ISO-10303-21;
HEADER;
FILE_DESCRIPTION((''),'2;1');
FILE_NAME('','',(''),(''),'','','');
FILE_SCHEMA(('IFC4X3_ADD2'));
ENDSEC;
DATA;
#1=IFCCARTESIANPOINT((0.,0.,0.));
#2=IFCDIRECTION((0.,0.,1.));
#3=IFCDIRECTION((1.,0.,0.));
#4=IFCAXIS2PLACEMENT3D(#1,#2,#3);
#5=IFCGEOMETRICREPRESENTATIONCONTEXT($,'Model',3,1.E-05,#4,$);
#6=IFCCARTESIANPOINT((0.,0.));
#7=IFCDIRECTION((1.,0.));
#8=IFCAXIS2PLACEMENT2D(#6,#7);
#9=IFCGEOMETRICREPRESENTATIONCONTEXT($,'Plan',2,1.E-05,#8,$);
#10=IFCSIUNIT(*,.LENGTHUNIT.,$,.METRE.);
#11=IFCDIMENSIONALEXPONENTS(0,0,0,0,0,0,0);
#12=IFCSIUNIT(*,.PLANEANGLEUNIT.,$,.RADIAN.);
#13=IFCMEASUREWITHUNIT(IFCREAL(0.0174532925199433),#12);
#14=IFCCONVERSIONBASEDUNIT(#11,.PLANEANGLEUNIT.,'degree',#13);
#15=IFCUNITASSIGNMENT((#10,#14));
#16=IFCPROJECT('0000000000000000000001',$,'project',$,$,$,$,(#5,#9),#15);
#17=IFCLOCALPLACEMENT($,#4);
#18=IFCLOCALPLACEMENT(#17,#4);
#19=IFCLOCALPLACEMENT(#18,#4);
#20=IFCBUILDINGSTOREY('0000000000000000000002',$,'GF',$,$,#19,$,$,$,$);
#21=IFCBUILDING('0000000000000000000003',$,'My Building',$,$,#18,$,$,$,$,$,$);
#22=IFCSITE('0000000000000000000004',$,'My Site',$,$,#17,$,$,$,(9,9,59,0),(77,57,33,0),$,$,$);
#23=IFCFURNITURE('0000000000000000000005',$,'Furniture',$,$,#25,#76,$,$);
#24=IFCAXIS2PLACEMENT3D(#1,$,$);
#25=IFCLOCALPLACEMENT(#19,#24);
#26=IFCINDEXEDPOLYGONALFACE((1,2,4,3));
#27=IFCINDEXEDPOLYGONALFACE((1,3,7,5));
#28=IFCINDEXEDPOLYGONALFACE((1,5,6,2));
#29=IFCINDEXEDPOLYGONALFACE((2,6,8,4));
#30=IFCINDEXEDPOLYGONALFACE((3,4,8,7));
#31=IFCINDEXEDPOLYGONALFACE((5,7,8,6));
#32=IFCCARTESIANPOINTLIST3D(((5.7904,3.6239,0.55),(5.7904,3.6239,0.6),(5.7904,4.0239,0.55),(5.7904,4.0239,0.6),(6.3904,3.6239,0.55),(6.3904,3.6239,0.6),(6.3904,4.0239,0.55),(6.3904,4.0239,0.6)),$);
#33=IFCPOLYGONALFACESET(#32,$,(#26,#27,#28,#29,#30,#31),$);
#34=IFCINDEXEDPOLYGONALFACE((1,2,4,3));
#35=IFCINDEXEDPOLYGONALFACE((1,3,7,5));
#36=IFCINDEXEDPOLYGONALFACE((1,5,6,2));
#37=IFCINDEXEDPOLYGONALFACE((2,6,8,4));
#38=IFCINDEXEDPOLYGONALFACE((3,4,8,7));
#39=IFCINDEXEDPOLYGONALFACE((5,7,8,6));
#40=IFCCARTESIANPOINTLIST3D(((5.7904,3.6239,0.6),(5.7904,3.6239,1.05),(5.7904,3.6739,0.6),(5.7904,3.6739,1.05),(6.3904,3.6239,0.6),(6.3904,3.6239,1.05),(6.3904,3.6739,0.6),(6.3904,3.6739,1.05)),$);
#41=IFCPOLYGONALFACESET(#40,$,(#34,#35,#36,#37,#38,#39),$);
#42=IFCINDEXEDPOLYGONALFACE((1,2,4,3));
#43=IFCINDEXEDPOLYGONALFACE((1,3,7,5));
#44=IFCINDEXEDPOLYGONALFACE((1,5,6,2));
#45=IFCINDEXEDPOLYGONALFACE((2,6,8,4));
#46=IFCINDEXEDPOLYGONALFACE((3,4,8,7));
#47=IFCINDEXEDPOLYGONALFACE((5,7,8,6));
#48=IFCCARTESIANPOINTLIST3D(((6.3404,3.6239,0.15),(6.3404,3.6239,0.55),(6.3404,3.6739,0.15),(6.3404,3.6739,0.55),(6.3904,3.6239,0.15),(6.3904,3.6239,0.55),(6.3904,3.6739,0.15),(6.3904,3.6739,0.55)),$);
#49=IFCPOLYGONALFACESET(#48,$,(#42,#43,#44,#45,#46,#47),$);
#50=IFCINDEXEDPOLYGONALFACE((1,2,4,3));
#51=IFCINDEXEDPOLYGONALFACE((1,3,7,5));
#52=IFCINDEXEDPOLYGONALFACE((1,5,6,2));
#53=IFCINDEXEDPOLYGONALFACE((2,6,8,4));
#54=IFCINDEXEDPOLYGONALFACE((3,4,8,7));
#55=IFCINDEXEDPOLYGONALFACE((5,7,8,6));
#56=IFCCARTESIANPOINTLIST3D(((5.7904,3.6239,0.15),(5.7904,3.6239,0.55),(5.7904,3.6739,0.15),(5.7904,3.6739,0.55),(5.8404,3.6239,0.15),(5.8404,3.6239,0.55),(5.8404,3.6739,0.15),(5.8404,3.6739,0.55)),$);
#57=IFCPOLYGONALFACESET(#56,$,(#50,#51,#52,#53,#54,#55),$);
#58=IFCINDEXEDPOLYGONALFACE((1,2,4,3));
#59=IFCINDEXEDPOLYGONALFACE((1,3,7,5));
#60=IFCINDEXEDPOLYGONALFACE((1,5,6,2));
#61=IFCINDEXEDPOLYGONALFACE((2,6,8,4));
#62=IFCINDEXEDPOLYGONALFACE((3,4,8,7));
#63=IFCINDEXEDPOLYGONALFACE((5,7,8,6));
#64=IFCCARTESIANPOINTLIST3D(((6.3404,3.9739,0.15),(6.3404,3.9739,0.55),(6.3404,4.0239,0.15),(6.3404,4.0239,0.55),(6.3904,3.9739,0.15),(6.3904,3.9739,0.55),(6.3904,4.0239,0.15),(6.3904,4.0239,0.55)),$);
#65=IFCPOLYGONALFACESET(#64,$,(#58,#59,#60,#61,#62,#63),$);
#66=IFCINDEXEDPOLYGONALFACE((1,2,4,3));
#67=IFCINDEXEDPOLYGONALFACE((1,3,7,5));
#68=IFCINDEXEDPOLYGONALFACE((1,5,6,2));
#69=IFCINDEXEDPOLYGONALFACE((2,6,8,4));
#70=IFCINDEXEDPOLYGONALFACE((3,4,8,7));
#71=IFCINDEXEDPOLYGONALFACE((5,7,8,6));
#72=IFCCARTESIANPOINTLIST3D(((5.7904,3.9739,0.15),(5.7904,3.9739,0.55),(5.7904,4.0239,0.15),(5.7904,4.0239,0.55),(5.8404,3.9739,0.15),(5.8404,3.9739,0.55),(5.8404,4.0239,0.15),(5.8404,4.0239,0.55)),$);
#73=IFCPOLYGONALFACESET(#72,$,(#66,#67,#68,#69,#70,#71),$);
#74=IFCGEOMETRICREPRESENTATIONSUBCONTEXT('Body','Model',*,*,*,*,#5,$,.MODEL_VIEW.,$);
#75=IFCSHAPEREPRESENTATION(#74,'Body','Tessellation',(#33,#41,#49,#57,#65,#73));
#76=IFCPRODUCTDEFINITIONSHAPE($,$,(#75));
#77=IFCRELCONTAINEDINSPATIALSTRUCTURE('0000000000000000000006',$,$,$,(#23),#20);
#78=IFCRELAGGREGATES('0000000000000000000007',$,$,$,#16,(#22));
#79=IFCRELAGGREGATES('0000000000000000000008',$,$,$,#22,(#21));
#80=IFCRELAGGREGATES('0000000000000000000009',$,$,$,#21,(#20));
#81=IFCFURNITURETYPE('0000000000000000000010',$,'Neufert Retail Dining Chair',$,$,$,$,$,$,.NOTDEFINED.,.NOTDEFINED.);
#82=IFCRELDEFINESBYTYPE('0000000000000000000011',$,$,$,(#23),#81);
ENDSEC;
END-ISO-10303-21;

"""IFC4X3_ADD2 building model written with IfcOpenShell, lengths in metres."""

from ifc_helpers import new_model, entity, si_unit, converted_unit, frame, origin_with_axes, origin_2d_with_axis, place, context, subcontext, project, spatial, line, indexed_curve, outline, extrude, shape, source, transform, mapped, type_object, type_shapes, element, save


model = new_model("IFC4X3_ADD2")

# Units and contexts
model_context = context("Model", 3, precision=1e-05, world=origin_with_axes())
plan_context = context("Plan", 2, precision=1e-05, world=origin_2d_with_axis())
body_context_1 = subcontext(model_context, "Body", "Model", "MODEL_VIEW")
body_context_2 = subcontext(plan_context, "Body", "Plan", "PLAN_VIEW")
ifc_project = project(units=[si_unit("LENGTHUNIT", "METRE"), converted_unit("PLANEANGLEUNIT", "degree", entity("IfcReal", 0.0174532925199433), si_unit("PLANEANGLEUNIT", "RADIAN"), dimensions=[0, 0, 0, 0, 0, 0, 0])], contexts=[model_context, plan_context])

# Site, building, storey
site_placement = place(None, origin_with_axes())
site = spatial("IfcSite", under=ifc_project, at=site_placement, Name="My Site", RefLatitude=(9, 9, 59, 0), RefLongitude=(77, 57, 33, 0))
building_placement = place(site_placement, origin_with_axes())
building = spatial("IfcBuilding", under=site, at=building_placement, Name="My Building")
storey_placement = place(building_placement, origin_with_axes())
storey = spatial("IfcBuildingStorey", under=building, at=storey_placement, Name="GF")

# Furniture
furniture_type = type_object("IfcFurnitureType", Name="Neufert Retail Dining Chair", AssemblyPlace="NOTDEFINED", PredefinedType="NOTDEFINED")
shared_shape_1 = source(origin_with_axes(), body_context_1, "Body", "SweptSolid", [
    extrude(outline(indexed_curve([(-0.3, 0.0), (0.3, 0.0), (0.3, -0.4), (-0.3, -0.4)], segments=[line(1, 2, 3, 4, 1)])), frame((0.0, 0.0, 0.45), z_axis=(0.0, 0.0, 1.0), x_axis=(1.0, 0.0, 0.0)), (0.0, 0.0, -1.0), 0.05),
    extrude(outline(indexed_curve([(-0.3, 0.0), (0.3, 0.0), (0.3, -0.05), (-0.3, -0.05)], segments=[line(1, 2, 3, 4, 1)])), frame((0.0, 0.0, 0.9), z_axis=(0.0, 0.0, 1.0), x_axis=(1.0, 0.0, 0.0)), (0.0, 0.0, -1.0), 0.45),
    extrude(outline(indexed_curve([(-0.3, 0.0), (-0.25, 0.0), (-0.25, -0.05), (-0.3, -0.05)], segments=[line(1, 2, 3, 4, 1)])), origin_with_axes(), (0.0, 0.0, 1.0), 0.4),
    extrude(outline(indexed_curve([(0.3, 0.0), (0.25, 0.0), (0.25, -0.05), (0.3, -0.05)], segments=[line(1, 2, 3, 4, 1)])), origin_with_axes(), (0.0, 0.0, 1.0), 0.4),
    extrude(outline(indexed_curve([(-0.3, -0.4), (-0.25, -0.4), (-0.25, -0.35), (-0.3, -0.35)], segments=[line(1, 2, 3, 4, 1)])), origin_with_axes(), (0.0, 0.0, 1.0), 0.4),
    extrude(outline(indexed_curve([(0.3, -0.4), (0.25, -0.4), (0.25, -0.35), (0.3, -0.35)], segments=[line(1, 2, 3, 4, 1)])), origin_with_axes(), (0.0, 0.0, 1.0), 0.4),
])
shared_shape_2 = source(origin_with_axes(), body_context_2, "Body", "Curve2D", [
    entity("IfcIndexedPolyCurve", entity("IfcCartesianPointList2D", [[-0.3, -0.4], [0.3, -0.4]])),
    entity("IfcIndexedPolyCurve", entity("IfcCartesianPointList2D", [[-0.3, -0.4], [-0.3, -0.3], [-0.2121, -0.0879], [0.0, 0.0], [0.2121, -0.0879], [0.3, -0.3], [0.3, -0.4]]), [entity("IfcLineIndex", [1, 2]), entity("IfcArcIndex", [2, 3, 4]), entity("IfcArcIndex", [4, 5, 6]), entity("IfcLineIndex", [6, 7])]),
    entity("IfcIndexedPolyCurve", entity("IfcCartesianPointList2D", [[-0.26, -0.4], [-0.26, -0.3], [-0.1838, -0.1162], [0.0, -0.04], [0.1838, -0.1162], [0.26, -0.3], [0.26, -0.4]]), [entity("IfcLineIndex", [1, 2]), entity("IfcArcIndex", [2, 3, 4]), entity("IfcArcIndex", [4, 5, 6]), entity("IfcLineIndex", [6, 7])]),
])
type_shapes(furniture_type, [shared_shape_1, shared_shape_2])
for number, where, z_axis, x_axis, name in (
    (1, (6.0904, 3.6239, 0.15), (0.0, 0.0, 1.0), (-1.0, 0.000002, 0.0), "Furniture"),
):
    element("IfcFurniture", number, at=place(storey_placement, frame(where, z_axis=z_axis, x_axis=x_axis)), inside=storey, type_object=furniture_type, Name=name, shapes=[
        shape(body_context_1, "Body", "MappedRepresentation", [mapped(shared_shape_1, transform((0.0, 0.0, 0.0), x_axis=(1.0, 0.0, 0.0), y_axis=(0.0, 1.0, 0.0), z_axis=(0.0, 0.0, 1.0), scale=1.0))]),
        shape(body_context_2, "Body", "MappedRepresentation", [mapped(shared_shape_2, transform((0.0, 0.0, 0.0), x_axis=(1.0, 0.0, 0.0), y_axis=(0.0, 1.0, 0.0), z_axis=(0.0, 0.0, 1.0), scale=1.0))]),
    ])

save(model, "model.ifc")
